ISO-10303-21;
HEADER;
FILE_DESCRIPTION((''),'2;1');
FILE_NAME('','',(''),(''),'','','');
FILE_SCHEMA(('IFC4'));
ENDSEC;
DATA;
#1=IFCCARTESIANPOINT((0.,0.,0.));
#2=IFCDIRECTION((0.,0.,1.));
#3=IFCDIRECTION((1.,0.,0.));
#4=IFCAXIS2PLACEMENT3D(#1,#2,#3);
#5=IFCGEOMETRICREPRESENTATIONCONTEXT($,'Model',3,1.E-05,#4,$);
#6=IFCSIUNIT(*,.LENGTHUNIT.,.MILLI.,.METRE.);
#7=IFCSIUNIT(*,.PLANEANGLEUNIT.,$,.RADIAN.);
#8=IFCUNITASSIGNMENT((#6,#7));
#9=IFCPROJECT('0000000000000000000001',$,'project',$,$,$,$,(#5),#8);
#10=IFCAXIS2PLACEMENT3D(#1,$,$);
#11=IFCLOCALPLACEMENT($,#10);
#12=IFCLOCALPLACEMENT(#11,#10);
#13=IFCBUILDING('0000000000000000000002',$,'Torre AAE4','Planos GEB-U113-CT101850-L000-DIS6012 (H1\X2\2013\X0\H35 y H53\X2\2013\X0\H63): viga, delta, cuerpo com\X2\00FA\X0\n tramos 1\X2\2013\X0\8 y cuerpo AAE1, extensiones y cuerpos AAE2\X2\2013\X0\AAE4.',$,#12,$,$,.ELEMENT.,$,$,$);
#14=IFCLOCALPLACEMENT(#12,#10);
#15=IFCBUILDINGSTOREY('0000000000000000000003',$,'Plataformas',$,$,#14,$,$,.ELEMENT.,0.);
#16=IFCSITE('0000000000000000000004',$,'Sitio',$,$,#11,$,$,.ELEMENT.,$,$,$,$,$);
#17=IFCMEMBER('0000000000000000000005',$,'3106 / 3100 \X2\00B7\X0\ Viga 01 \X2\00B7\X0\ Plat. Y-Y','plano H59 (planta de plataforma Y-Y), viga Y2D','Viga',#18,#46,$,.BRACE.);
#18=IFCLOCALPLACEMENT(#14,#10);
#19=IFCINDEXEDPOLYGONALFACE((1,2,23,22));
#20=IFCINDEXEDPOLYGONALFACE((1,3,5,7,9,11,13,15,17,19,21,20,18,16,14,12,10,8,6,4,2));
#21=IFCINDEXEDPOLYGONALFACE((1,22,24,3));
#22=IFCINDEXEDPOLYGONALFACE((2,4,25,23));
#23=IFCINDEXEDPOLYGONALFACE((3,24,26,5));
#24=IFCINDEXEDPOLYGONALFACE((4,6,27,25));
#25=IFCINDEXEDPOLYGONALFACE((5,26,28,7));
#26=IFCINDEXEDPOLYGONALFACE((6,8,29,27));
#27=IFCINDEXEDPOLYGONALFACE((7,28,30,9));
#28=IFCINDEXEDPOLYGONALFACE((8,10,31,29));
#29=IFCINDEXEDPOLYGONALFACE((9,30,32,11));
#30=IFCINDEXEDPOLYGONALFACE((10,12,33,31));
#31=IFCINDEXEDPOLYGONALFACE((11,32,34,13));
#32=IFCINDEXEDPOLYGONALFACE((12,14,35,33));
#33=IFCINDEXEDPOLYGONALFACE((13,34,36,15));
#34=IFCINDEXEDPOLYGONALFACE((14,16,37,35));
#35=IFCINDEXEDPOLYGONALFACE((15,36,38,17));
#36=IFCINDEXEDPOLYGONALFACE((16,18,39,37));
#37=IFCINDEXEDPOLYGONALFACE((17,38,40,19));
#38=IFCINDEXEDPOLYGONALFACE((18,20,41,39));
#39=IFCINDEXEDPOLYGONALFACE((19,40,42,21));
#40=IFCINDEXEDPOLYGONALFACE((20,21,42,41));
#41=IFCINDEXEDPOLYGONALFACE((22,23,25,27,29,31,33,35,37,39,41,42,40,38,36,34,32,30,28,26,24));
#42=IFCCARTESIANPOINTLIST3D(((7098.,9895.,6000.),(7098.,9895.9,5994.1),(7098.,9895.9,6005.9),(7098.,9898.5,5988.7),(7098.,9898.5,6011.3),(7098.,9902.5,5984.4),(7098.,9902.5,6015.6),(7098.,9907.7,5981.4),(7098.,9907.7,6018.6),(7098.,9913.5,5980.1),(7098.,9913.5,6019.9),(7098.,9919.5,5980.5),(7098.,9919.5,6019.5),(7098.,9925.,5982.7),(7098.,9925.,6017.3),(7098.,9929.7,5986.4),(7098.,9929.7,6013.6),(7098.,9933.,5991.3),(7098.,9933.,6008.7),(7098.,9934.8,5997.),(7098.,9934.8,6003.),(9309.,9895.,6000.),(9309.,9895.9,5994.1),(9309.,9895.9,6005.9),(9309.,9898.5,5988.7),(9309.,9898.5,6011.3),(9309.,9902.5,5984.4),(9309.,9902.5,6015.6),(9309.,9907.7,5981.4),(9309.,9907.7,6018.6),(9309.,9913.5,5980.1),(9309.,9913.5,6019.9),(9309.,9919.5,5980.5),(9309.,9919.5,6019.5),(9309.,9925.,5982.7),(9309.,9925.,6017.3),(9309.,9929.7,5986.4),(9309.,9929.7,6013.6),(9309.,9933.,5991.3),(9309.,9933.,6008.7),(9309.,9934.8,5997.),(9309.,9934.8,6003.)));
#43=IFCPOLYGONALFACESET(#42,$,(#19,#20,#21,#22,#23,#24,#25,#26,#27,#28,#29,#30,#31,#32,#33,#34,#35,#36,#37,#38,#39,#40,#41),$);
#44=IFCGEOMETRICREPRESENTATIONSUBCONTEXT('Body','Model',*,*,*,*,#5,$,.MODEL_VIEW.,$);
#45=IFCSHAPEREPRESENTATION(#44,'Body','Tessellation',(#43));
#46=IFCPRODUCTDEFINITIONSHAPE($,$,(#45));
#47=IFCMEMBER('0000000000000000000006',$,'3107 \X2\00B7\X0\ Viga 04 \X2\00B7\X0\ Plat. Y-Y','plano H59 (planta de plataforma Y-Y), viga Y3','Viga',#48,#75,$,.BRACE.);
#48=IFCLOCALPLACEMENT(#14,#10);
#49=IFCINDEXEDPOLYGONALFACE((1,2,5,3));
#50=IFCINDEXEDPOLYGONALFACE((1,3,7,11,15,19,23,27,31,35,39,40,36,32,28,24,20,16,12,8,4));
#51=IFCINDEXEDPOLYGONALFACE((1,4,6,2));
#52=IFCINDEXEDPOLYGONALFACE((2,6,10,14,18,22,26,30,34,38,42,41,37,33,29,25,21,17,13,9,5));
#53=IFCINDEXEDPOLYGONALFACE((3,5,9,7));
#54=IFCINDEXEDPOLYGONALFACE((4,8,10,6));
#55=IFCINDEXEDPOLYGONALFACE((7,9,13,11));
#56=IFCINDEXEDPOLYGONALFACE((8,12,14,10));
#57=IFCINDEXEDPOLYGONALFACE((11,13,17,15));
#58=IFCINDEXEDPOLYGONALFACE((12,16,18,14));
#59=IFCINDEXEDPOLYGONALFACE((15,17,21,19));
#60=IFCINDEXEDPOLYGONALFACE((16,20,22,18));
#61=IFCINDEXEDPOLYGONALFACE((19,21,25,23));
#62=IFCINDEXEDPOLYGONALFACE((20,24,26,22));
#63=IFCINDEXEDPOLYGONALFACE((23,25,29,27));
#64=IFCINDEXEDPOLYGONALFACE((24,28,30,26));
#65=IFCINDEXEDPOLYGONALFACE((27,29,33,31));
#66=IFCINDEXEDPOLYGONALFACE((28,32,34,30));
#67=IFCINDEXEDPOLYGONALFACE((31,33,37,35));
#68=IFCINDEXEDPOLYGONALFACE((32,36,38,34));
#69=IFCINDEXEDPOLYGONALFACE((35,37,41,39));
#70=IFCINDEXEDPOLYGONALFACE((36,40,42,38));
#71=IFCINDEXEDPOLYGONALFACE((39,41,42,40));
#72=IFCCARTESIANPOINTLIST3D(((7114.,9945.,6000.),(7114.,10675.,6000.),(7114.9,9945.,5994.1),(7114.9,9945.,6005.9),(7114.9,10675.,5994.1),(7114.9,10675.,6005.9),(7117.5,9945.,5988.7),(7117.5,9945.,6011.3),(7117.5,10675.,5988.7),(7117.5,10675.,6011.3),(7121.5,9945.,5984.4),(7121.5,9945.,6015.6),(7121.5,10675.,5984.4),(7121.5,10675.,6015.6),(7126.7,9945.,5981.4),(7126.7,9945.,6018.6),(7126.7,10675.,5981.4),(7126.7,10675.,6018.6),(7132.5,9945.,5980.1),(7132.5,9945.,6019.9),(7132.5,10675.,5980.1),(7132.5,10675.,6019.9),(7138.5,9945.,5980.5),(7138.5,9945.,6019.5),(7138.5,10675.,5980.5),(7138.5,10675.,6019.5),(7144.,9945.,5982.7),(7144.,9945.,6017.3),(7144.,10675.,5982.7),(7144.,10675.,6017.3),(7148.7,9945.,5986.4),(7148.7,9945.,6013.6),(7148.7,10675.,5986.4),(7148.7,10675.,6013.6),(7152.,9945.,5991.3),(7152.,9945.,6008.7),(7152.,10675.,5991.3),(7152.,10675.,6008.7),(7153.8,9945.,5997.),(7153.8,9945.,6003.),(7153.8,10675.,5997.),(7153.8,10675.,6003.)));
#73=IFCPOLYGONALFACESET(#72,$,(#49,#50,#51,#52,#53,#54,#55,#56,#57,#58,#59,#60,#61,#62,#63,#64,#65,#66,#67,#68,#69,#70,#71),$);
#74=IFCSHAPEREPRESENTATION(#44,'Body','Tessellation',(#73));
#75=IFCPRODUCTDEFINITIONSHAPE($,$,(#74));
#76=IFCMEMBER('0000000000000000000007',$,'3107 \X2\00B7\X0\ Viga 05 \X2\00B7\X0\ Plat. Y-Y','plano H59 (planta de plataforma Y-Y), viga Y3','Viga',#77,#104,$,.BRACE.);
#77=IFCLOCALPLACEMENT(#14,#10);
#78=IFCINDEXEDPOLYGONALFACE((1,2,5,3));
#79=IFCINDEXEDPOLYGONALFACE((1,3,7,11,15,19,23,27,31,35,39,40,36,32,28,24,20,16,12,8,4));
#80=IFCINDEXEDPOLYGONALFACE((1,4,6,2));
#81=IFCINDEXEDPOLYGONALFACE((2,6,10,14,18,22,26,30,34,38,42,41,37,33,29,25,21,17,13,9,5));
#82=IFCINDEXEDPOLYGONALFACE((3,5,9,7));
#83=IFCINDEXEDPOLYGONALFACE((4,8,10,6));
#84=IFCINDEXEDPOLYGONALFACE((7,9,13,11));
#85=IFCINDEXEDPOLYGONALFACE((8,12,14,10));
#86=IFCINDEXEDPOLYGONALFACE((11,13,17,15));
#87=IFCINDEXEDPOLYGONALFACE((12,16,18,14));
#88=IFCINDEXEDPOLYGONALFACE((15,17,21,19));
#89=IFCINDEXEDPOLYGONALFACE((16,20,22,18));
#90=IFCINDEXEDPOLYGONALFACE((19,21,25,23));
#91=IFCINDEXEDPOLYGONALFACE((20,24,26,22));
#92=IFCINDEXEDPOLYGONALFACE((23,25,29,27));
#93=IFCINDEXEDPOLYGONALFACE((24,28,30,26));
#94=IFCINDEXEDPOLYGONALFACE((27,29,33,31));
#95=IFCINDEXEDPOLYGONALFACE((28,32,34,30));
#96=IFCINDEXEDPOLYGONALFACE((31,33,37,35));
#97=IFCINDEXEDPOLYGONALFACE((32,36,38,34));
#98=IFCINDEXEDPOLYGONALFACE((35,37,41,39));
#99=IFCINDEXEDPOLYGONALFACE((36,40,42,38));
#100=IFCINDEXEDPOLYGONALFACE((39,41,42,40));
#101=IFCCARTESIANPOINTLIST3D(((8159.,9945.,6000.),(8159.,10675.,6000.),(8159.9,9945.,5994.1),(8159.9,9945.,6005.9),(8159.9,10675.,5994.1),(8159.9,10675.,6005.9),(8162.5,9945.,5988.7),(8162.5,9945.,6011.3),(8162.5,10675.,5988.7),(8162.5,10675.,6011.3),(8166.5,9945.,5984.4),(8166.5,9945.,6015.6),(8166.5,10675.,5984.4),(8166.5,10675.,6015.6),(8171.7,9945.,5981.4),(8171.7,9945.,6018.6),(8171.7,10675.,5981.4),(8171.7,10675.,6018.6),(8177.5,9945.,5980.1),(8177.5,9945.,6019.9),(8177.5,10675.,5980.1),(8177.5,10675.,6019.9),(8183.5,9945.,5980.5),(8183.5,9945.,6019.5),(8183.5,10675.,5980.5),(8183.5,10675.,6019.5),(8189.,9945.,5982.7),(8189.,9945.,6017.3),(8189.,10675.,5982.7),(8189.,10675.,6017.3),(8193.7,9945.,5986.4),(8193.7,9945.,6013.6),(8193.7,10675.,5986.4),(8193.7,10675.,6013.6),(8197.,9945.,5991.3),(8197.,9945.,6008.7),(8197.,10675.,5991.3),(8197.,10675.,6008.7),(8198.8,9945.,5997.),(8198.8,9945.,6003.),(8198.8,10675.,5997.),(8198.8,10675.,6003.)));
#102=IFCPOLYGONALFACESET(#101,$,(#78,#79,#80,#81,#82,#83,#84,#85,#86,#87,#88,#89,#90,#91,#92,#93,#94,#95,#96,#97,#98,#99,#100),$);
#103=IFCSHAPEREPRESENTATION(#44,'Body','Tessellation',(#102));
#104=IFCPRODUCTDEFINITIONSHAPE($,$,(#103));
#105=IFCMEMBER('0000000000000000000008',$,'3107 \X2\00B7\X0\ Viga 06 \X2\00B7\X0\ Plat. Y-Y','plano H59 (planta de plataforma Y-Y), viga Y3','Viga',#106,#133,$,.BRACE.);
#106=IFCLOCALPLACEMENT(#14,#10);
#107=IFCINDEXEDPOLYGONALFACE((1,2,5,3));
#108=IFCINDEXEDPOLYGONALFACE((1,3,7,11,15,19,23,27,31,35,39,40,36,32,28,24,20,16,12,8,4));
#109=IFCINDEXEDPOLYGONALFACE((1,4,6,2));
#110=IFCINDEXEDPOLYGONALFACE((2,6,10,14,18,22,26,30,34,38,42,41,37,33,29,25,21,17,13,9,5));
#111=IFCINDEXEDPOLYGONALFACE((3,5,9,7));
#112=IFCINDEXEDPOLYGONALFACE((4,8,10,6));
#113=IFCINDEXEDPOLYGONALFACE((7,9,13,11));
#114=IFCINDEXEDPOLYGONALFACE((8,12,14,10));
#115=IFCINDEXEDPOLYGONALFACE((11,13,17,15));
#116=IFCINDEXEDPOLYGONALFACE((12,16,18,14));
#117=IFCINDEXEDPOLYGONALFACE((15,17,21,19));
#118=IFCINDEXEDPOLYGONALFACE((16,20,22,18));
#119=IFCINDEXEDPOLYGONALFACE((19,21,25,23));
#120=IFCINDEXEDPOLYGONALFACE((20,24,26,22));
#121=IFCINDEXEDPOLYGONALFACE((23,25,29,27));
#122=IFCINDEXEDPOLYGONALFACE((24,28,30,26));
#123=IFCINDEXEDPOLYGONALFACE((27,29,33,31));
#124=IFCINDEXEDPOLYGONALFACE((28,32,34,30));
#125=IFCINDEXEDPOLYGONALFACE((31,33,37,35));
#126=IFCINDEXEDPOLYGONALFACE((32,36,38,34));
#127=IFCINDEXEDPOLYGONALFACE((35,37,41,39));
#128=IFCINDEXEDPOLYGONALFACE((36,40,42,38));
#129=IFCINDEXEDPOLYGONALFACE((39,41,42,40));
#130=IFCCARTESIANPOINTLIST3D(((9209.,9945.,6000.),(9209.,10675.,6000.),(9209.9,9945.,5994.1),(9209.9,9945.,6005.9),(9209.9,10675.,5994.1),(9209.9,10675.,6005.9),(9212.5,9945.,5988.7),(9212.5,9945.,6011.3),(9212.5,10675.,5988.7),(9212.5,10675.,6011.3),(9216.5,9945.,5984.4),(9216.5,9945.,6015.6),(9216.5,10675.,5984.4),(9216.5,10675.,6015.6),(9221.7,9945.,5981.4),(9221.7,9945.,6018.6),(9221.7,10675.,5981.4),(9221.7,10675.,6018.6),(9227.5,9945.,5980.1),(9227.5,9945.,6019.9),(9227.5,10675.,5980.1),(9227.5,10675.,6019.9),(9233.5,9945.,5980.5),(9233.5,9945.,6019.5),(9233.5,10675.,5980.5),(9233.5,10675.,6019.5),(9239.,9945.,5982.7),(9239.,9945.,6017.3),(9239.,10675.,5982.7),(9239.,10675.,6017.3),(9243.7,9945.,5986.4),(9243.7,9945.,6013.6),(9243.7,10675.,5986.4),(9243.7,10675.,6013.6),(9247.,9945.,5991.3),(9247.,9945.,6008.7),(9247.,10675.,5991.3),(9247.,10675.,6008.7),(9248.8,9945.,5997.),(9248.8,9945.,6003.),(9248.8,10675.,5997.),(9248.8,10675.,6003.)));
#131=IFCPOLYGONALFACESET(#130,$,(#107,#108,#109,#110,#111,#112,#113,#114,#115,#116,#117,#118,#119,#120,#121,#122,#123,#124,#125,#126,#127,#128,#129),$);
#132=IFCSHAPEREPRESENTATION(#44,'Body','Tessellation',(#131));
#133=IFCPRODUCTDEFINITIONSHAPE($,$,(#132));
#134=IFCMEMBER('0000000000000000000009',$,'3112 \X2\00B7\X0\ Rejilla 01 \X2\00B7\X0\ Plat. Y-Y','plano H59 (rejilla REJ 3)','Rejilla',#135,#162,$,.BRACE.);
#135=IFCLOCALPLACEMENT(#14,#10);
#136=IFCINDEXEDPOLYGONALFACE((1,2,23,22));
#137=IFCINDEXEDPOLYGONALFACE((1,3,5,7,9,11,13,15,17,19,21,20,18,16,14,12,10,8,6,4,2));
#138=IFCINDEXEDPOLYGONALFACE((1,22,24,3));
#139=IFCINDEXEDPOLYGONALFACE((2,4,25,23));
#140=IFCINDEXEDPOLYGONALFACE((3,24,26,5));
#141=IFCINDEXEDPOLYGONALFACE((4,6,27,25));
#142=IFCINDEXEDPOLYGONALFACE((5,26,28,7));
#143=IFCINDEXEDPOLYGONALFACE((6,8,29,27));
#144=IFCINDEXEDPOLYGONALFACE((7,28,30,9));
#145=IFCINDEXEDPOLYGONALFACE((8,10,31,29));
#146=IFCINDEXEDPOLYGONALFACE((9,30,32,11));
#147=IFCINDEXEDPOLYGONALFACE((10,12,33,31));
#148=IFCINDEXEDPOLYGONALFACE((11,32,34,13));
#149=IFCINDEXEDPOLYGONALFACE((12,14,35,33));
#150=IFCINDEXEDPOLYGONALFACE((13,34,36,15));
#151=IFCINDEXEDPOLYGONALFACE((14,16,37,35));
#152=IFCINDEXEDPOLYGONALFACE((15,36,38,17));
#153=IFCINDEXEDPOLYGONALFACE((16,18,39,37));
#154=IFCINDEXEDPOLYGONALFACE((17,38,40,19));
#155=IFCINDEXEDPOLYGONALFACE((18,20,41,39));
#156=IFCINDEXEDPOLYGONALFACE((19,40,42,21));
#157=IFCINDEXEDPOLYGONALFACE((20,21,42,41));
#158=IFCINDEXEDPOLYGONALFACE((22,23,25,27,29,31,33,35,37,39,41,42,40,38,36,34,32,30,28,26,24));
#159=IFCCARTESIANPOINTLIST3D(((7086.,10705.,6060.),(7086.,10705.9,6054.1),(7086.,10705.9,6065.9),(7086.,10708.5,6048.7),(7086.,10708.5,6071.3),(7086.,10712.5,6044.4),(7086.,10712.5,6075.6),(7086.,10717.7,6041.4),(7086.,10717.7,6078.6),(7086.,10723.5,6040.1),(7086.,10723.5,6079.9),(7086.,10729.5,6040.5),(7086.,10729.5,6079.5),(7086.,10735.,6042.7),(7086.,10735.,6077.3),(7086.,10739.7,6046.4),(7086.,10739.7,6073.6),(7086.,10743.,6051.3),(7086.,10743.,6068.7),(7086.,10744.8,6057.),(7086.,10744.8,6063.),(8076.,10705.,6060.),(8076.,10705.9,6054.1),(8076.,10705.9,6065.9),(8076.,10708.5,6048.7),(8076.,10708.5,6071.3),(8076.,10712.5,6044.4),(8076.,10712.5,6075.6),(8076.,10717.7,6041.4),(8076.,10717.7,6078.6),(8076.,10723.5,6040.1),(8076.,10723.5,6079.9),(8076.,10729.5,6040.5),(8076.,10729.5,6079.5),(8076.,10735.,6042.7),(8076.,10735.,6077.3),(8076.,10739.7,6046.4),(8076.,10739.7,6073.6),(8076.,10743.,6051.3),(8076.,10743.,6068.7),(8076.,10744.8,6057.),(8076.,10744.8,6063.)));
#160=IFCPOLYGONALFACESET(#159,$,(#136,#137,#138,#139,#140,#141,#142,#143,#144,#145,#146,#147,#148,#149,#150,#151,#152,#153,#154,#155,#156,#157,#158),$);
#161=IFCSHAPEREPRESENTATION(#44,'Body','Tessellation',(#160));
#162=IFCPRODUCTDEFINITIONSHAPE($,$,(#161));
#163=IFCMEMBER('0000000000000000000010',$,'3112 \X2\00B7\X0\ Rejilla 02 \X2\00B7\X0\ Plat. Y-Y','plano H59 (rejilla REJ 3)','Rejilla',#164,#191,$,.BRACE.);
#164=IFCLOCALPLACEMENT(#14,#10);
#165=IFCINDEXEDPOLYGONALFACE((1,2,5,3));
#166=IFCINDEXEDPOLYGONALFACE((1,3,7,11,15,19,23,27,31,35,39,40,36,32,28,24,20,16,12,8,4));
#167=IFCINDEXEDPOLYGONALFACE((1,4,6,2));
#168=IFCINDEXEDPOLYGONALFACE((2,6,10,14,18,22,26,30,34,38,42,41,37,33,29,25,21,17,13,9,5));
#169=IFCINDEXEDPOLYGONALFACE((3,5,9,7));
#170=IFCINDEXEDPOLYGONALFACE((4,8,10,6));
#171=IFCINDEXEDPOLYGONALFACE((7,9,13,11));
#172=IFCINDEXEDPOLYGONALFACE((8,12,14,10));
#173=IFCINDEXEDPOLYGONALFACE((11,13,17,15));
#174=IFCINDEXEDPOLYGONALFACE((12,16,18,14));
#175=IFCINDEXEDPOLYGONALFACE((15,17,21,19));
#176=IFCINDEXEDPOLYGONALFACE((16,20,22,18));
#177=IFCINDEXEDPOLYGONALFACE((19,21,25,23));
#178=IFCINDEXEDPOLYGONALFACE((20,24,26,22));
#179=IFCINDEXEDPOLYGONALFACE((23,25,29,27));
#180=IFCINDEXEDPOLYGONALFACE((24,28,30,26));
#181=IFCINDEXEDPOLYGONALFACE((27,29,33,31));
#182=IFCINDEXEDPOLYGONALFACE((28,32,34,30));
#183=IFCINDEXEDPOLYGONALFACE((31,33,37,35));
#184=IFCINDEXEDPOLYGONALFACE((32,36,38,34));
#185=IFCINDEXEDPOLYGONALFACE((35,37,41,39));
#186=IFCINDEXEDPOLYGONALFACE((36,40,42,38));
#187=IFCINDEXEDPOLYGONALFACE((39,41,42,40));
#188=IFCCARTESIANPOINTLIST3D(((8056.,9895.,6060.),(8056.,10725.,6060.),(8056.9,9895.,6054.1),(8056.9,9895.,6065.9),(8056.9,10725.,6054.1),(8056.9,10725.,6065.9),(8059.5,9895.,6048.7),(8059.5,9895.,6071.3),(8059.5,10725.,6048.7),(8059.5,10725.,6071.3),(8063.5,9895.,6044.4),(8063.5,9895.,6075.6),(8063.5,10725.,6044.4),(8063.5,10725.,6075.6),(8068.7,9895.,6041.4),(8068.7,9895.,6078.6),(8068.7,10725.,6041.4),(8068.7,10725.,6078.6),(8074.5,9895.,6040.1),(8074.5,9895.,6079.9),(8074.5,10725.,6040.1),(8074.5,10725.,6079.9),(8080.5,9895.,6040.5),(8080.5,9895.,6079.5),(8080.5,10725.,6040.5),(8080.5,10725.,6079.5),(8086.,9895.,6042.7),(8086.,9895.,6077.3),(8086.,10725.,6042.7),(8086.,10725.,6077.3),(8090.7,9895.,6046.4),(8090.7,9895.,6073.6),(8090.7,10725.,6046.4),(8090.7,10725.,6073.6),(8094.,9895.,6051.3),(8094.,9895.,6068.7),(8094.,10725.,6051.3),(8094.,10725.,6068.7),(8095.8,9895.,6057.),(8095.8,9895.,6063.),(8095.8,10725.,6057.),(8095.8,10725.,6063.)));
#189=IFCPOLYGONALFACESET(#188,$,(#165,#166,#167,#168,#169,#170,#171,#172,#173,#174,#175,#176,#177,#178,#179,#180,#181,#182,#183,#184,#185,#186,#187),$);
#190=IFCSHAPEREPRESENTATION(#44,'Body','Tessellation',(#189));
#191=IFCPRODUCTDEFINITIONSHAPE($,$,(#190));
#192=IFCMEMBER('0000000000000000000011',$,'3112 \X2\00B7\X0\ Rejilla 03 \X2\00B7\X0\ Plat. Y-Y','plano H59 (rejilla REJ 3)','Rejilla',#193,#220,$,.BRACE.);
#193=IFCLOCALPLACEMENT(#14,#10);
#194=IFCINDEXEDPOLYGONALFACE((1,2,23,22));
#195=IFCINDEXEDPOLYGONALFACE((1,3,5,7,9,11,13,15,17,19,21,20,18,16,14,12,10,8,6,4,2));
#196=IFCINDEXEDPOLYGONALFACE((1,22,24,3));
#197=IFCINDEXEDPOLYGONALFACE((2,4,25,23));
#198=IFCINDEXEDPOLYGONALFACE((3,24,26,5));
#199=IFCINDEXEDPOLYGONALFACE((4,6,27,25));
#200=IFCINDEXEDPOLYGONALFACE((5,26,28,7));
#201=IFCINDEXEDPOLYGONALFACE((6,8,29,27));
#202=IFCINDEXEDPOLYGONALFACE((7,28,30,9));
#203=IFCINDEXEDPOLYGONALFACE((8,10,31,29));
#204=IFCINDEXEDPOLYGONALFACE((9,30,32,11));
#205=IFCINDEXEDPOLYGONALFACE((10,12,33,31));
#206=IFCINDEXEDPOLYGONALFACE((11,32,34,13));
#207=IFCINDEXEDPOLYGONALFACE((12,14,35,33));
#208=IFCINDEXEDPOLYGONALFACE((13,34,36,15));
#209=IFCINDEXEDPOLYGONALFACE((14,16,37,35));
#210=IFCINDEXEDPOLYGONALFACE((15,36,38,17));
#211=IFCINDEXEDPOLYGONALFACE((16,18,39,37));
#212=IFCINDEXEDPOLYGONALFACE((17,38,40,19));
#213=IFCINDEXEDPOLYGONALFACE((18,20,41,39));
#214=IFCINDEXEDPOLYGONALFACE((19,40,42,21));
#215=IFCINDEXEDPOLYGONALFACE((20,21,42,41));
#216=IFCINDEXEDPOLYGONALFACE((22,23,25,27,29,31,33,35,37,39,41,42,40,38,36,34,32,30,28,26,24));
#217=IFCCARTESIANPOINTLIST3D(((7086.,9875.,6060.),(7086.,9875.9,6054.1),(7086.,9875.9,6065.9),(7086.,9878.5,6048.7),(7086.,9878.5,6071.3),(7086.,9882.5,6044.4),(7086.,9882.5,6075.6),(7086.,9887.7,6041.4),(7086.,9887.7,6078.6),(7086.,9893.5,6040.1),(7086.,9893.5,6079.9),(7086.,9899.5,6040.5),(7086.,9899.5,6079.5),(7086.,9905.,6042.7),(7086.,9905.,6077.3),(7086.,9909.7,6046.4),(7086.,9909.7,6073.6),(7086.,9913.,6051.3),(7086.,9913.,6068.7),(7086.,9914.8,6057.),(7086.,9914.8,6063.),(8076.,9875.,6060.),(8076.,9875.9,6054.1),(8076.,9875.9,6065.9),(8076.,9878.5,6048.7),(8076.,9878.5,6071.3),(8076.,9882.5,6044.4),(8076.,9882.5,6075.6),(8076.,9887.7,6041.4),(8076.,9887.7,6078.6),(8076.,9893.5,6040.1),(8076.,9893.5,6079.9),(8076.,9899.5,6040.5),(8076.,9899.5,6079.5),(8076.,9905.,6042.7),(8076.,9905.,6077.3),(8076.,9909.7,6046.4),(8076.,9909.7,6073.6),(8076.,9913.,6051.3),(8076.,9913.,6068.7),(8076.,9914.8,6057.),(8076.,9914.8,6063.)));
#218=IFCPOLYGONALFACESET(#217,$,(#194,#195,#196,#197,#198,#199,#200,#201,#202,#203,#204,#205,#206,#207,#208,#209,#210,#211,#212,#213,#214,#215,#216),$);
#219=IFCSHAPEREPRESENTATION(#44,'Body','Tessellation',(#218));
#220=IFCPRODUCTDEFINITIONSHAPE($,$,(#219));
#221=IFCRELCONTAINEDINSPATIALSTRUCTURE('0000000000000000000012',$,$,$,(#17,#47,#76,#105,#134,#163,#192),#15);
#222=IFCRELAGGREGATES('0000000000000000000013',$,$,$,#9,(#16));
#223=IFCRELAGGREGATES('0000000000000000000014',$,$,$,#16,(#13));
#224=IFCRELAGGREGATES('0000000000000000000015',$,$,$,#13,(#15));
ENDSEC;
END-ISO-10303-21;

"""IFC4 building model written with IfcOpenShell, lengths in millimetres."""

from ifc_helpers import new_model, si_unit, frame, origin, origin_with_axes, place, context, subcontext, project, spatial, circle, extrude, element, save


model = new_model("IFC4")

# Units and contexts
model_context = context("Model", 3, precision=1e-05, world=origin_with_axes())
body_context = subcontext(model_context, "Body", "Model", "MODEL_VIEW")
ifc_project = project(units=[si_unit("LENGTHUNIT", "METRE", prefix="MILLI"), si_unit("PLANEANGLEUNIT", "RADIAN")], contexts=[model_context])

# Site, building, storey
site_placement = place(None, origin())
site = spatial("IfcSite", under=ifc_project, at=site_placement, Name="Sitio", CompositionType="ELEMENT")
building_placement = place(site_placement, origin())
building = spatial("IfcBuilding", under=site, at=building_placement, Name="Torre AAE4", Description="Planos GEB-U113-CT101850-L000-DIS6012 (H1–H35 y H53–H63): viga, delta, cuerpo común tramos 1–8 y cuerpo AAE1, extensiones y cuerpos AAE2–AAE4.", CompositionType="ELEMENT")
storey_placement = place(building_placement, origin())
storey = spatial("IfcBuildingStorey", under=building, at=storey_placement, Name="Plataformas", CompositionType="ELEMENT", Elevation=0.0)

# Members
member_1_placement = place(storey_placement, frame((7098.0, 9915.0, 6000.0), z_axis=(1.0, 0.0, 0.0), x_axis=(0.0, -1.0, 0.0)))
element("IfcMember", 1, at=member_1_placement, inside=storey, Name="3106 / 3100 · Viga 01 · Plat. Y-Y", Description="plano H59 (planta de plataforma Y-Y), viga Y2D", ObjectType="Viga", PredefinedType="BRACE", context=body_context, shape_type="SweptSolid", body=[
    extrude(circle(Radius=20.0), None, (0.0, 0.0, 1.0), 2211.0),
])
for number, where, z_axis, x_axis, name in (
    (2, (7134.0, 10675.0, 6000.0), (0.0, -1.0, 0.0), (-1.0, 0.0, 0.0), "3107 · Viga 04 · Plat. Y-Y"),
    (3, (8179.0, 10675.0, 6000.0), (0.0, -1.0, 0.0), (-1.0, 0.0, 0.0), "3107 · Viga 05 · Plat. Y-Y"),
    (4, (9229.0, 10675.0, 6000.0), (0.0, -1.0, 0.0), (-1.0, 0.0, 0.0), "3107 · Viga 06 · Plat. Y-Y"),
):
    element("IfcMember", number, at=place(storey_placement, frame(where, z_axis=z_axis, x_axis=x_axis)), inside=storey, Name=name, Description="plano H59 (planta de plataforma Y-Y), viga Y3", ObjectType="Viga", PredefinedType="BRACE", context=body_context, shape_type="SweptSolid", body=[
        extrude(circle(Radius=20.0), None, (0.0, 0.0, 1.0), 730.0),
    ])
member_2_placement = place(storey_placement, frame((7086.0, 10725.0, 6060.0), z_axis=(1.0, 0.0, 0.0), x_axis=(0.0, -1.0, 0.0)))
element("IfcMember", 5, at=member_2_placement, inside=storey, Name="3112 · Rejilla 01 · Plat. Y-Y", Description="plano H59 (rejilla REJ 3)", ObjectType="Rejilla", PredefinedType="BRACE", context=body_context, shape_type="SweptSolid", body=[
    extrude(circle(Radius=20.0), None, (0.0, 0.0, 1.0), 990.0),
])
member_3_placement = place(storey_placement, frame((8076.0, 10725.0, 6060.0), z_axis=(0.0, -1.0, 0.0), x_axis=(-1.0, 0.0, 0.0)))
element("IfcMember", 6, at=member_3_placement, inside=storey, Name="3112 · Rejilla 02 · Plat. Y-Y", Description="plano H59 (rejilla REJ 3)", ObjectType="Rejilla", PredefinedType="BRACE", context=body_context, shape_type="SweptSolid", body=[
    extrude(circle(Radius=20.0), None, (0.0, 0.0, 1.0), 830.0),
])
member_4_placement = place(storey_placement, frame((8076.0, 9895.0, 6060.0), z_axis=(-1.0, 0.0, 0.0), x_axis=(0.0, -1.0, 0.0)))
element("IfcMember", 7, at=member_4_placement, inside=storey, Name="3112 · Rejilla 03 · Plat. Y-Y", Description="plano H59 (rejilla REJ 3)", ObjectType="Rejilla", PredefinedType="BRACE", context=body_context, shape_type="SweptSolid", body=[
    extrude(circle(Radius=20.0), None, (0.0, 0.0, 1.0), 990.0),
])

save(model, "model.ifc")
